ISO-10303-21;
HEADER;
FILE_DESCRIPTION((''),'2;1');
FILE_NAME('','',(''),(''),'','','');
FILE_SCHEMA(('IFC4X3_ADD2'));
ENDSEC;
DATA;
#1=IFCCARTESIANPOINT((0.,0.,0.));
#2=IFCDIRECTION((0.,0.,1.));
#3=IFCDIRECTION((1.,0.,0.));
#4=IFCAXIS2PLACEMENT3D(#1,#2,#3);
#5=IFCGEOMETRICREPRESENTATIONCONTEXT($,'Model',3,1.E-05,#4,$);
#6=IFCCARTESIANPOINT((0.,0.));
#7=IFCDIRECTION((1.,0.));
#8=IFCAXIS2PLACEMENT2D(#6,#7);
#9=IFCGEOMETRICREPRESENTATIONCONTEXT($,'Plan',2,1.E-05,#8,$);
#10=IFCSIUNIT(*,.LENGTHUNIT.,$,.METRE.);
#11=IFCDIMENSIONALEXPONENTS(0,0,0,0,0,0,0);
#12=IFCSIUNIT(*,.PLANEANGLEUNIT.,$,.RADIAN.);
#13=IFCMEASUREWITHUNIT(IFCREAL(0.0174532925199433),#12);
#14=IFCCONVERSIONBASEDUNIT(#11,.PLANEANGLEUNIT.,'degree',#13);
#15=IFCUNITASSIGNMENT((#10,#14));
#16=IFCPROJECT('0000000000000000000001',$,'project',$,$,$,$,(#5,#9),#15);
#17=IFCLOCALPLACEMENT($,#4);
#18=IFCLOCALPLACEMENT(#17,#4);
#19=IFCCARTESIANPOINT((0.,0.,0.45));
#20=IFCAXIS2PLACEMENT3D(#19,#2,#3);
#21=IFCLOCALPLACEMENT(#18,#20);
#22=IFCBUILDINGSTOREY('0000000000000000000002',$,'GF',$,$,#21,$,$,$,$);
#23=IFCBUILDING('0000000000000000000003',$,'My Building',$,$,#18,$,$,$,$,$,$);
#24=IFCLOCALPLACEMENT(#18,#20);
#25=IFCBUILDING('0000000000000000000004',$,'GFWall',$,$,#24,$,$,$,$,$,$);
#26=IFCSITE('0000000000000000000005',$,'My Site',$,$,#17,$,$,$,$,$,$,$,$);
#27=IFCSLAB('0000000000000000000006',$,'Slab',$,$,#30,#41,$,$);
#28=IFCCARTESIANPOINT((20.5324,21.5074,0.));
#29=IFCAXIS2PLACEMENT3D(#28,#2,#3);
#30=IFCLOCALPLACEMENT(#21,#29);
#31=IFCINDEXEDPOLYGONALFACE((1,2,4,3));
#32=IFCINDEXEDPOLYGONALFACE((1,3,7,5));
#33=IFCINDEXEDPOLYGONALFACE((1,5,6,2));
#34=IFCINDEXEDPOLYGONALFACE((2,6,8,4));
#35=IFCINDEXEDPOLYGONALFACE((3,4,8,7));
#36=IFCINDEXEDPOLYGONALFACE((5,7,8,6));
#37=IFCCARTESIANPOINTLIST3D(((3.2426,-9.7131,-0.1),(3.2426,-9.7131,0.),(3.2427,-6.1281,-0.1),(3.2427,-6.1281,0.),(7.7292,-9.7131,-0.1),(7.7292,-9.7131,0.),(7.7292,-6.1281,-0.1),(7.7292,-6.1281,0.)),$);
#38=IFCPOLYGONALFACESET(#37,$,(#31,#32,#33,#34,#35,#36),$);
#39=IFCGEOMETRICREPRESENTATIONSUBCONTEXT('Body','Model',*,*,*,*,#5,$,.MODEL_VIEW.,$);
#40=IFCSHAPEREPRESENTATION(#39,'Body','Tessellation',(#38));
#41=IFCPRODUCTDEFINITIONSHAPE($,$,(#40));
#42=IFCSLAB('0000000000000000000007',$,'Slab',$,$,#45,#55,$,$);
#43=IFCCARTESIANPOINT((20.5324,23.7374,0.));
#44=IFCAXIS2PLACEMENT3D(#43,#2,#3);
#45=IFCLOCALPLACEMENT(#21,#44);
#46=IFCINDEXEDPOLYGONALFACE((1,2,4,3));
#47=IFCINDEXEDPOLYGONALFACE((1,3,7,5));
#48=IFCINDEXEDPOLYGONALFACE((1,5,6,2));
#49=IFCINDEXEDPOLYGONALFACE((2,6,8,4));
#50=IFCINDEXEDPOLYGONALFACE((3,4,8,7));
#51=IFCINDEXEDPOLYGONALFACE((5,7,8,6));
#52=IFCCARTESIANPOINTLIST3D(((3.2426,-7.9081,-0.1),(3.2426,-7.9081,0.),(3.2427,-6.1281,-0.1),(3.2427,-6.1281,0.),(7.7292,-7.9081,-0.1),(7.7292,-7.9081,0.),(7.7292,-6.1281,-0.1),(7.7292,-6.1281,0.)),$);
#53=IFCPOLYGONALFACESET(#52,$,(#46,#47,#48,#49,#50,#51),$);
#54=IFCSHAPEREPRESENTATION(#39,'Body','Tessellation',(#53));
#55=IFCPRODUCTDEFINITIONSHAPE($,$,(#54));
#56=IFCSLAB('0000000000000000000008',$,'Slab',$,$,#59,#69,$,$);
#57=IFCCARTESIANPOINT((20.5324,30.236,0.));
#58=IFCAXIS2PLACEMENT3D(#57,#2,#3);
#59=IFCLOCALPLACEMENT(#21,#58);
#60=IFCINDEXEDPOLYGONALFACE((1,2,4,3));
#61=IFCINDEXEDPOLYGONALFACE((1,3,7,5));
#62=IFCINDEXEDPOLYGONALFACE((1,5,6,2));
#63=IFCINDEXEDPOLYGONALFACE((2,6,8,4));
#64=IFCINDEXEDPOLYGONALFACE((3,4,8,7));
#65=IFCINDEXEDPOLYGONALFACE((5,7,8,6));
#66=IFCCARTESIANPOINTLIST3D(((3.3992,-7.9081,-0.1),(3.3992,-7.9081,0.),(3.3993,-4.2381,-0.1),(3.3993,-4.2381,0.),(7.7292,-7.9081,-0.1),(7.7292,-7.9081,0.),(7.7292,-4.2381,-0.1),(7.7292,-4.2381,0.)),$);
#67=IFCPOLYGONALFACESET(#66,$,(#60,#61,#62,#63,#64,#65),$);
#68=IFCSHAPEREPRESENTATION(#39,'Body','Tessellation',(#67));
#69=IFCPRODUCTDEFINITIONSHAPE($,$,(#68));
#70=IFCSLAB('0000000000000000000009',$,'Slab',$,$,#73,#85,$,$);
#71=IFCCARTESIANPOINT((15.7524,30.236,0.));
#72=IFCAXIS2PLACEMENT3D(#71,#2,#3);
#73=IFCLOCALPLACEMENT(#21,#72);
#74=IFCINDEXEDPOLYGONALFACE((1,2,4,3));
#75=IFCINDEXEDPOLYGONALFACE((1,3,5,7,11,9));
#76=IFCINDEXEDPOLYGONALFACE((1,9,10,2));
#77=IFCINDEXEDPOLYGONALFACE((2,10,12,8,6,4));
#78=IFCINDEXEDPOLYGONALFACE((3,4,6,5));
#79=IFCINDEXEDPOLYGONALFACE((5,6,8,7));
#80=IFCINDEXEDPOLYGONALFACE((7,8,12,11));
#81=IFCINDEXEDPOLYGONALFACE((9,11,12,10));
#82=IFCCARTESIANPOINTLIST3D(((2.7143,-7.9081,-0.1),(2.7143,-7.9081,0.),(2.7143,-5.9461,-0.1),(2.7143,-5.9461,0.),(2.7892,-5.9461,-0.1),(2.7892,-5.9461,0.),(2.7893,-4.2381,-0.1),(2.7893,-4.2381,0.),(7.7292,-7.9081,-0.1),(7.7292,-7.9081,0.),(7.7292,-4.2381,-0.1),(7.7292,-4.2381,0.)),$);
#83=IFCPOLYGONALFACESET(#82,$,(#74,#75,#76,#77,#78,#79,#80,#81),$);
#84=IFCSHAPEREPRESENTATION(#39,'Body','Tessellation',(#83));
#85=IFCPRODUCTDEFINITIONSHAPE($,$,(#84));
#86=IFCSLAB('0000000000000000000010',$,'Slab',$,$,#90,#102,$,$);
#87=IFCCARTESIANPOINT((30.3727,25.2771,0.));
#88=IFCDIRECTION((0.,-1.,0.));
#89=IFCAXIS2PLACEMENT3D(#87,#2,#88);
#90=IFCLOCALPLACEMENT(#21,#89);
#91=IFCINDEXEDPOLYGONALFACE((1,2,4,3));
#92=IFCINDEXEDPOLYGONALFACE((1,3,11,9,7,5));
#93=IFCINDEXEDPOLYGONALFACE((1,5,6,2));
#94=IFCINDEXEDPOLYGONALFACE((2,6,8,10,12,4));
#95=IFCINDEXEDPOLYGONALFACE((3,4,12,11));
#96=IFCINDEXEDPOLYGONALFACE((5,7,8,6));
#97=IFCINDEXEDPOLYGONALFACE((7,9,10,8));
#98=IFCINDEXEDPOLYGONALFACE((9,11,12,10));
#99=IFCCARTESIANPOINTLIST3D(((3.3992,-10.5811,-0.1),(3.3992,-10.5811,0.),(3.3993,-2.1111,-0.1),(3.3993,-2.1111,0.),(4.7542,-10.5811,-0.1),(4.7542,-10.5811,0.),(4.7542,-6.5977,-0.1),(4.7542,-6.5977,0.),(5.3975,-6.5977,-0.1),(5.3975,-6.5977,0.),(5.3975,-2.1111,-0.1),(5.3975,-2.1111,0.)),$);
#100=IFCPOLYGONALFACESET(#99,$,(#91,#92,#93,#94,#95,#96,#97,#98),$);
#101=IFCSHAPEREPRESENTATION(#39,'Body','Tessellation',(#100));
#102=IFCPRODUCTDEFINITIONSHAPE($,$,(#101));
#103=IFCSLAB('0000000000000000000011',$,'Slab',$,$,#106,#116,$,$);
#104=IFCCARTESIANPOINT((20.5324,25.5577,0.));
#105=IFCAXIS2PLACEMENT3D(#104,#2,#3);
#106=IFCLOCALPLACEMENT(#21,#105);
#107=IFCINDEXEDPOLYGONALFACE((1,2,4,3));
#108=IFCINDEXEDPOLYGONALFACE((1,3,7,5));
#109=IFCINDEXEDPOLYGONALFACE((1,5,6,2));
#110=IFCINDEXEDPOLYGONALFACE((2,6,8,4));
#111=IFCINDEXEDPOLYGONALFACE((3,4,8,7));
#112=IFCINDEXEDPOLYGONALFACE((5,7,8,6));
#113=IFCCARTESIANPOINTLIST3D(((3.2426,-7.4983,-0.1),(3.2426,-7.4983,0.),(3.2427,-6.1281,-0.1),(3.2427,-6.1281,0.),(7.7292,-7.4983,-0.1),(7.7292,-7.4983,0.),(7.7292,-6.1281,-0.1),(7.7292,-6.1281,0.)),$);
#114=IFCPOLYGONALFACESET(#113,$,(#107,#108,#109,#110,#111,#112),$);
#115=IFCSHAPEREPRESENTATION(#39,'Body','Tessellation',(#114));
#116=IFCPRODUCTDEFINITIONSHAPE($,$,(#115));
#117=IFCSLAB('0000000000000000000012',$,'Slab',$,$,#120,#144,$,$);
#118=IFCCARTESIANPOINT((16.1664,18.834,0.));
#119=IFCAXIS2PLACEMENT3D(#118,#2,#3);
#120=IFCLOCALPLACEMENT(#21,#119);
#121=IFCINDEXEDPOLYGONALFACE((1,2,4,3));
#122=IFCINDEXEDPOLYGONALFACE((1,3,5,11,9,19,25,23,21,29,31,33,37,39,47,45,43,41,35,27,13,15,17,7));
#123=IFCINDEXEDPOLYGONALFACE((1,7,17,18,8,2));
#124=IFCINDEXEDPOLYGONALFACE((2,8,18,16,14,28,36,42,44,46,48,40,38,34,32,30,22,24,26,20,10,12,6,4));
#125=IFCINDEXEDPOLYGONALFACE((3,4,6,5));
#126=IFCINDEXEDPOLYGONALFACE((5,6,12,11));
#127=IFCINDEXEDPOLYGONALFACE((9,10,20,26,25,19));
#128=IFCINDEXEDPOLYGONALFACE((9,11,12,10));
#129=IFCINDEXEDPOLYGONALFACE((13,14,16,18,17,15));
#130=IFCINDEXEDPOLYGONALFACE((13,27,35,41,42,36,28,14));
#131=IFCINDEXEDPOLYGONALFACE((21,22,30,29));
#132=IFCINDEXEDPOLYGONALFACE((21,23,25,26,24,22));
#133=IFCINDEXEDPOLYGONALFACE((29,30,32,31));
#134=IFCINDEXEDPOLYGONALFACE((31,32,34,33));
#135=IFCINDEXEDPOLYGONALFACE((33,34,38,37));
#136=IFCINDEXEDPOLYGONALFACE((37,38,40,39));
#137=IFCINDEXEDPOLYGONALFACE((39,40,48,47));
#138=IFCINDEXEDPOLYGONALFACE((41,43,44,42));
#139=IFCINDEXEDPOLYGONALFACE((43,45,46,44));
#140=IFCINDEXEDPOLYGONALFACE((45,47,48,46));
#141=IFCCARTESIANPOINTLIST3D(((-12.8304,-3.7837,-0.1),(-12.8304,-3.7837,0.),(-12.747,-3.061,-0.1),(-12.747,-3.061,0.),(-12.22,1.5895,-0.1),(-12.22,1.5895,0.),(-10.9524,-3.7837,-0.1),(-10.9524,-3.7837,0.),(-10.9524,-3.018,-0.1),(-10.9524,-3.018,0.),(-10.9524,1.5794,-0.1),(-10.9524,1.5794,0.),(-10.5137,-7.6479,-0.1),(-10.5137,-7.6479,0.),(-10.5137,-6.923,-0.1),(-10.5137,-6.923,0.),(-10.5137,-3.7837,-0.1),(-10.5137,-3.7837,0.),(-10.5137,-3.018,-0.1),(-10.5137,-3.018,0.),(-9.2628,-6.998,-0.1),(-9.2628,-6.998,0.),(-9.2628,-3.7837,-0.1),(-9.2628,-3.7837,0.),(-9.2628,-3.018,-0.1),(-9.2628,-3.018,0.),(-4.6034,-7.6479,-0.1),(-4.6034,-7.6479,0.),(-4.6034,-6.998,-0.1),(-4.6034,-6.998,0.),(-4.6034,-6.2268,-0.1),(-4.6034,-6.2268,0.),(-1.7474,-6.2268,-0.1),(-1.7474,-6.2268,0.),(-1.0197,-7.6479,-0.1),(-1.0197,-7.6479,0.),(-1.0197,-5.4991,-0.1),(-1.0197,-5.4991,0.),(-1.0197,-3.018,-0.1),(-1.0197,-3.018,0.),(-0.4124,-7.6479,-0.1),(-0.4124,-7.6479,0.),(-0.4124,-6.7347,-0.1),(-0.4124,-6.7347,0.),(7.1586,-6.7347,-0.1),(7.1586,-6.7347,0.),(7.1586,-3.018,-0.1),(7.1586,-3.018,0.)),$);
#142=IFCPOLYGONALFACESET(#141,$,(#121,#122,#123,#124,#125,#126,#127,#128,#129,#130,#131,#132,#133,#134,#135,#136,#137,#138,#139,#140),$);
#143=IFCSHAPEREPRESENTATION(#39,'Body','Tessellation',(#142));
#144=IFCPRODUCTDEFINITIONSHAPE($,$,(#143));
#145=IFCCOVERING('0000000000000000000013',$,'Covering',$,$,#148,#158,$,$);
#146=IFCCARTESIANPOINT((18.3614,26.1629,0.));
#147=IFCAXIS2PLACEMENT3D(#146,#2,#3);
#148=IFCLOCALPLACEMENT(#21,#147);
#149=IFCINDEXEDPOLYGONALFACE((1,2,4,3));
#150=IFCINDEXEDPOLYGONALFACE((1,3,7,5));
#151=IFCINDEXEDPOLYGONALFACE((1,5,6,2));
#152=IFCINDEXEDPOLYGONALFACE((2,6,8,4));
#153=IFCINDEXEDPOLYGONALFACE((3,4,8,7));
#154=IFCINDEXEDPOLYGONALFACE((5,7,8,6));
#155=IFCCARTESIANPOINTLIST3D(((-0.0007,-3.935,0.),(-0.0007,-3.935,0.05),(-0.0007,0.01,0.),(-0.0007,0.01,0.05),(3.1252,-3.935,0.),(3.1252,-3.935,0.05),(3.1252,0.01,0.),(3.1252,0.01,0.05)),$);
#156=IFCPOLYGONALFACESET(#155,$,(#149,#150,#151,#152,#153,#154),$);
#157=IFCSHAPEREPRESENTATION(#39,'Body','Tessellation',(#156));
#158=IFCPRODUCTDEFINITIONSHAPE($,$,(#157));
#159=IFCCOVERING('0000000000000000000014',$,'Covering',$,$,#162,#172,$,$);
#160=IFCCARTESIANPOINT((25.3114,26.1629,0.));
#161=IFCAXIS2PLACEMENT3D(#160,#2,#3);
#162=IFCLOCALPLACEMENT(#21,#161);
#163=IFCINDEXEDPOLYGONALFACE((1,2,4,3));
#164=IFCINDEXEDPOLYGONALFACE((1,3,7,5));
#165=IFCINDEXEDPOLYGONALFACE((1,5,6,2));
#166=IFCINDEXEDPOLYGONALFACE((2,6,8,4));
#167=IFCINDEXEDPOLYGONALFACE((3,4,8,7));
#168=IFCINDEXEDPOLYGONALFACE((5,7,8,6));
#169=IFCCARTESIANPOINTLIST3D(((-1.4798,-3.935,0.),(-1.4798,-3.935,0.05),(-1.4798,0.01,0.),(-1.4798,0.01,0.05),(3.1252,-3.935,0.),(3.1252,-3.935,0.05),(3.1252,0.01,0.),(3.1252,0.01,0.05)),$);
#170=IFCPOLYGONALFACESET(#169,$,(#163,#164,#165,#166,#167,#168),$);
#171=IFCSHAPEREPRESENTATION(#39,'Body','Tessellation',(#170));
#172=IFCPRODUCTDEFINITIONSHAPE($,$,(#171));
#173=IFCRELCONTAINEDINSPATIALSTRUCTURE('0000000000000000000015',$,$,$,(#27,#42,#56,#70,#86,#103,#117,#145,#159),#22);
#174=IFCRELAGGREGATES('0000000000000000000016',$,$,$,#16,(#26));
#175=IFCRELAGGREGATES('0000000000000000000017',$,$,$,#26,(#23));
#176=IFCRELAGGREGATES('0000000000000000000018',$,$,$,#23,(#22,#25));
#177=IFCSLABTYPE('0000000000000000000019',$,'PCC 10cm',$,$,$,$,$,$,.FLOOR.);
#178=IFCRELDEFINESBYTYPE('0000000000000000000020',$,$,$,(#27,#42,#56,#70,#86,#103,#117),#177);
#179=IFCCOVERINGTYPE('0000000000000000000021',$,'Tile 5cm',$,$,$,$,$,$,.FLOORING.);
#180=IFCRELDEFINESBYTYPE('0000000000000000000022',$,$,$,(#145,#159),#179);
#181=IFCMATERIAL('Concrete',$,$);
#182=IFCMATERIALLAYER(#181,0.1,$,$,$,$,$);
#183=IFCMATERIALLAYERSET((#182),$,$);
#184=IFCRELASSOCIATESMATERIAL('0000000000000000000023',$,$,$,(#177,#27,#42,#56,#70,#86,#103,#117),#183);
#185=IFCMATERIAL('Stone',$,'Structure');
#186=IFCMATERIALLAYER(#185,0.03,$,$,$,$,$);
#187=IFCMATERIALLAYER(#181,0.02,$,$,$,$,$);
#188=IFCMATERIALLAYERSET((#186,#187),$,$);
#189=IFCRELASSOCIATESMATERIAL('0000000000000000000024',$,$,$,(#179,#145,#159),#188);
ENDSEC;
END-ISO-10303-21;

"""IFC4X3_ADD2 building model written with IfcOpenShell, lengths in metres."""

from ifc_helpers import new_model, entity, si_unit, converted_unit, frame, origin_with_axes, origin_2d_with_axis, place, context, subcontext, project, spatial, indexed_curve, outline, extrude, material, layer, layer_set, layer_usage, type_object, element, save


model = new_model("IFC4X3_ADD2")

# Units and contexts
model_context = context("Model", 3, precision=1e-05, world=origin_with_axes())
plan_context = context("Plan", 2, precision=1e-05, world=origin_2d_with_axis())
body_context_1 = subcontext(model_context, "Body", "Model", "MODEL_VIEW")
ifc_project = project(units=[si_unit("LENGTHUNIT", "METRE"), converted_unit("PLANEANGLEUNIT", "degree", entity("IfcReal", 0.0174532925199433), si_unit("PLANEANGLEUNIT", "RADIAN"), dimensions=[0, 0, 0, 0, 0, 0, 0])], contexts=[model_context, plan_context])

# Site, building, storey
site_placement = place(None, origin_with_axes())
site = spatial("IfcSite", under=ifc_project, at=site_placement, Name="My Site")
building_1_placement = place(site_placement, origin_with_axes())
building_1 = spatial("IfcBuilding", under=site, at=building_1_placement, Name="My Building")
storey_placement = place(building_1_placement, frame((0.0, 0.0, 0.45), z_axis=(0.0, 0.0, 1.0), x_axis=(1.0, 0.0, 0.0)))
storey = spatial("IfcBuildingStorey", under=building_1, at=storey_placement, Name="GF")

# Slabs
ifc_material_1 = material(Name="Concrete")
ifc_layer_1 = layer(ifc_material_1, 0.1)
ifc_layer_set_1 = layer_set([ifc_layer_1])
ifc_layer_usage_1 = layer_usage(ifc_layer_set_1, "AXIS3", "POSITIVE", -0.1)
slab_type = type_object("IfcSlabType", Name="PCC 10cm", PredefinedType="FLOOR", material=ifc_layer_set_1)
slab_1_placement = place(storey_placement, frame((20.5324, 21.5074, 0.0), z_axis=(0.0, 0.0, 1.0), x_axis=(1.0, 0.0, 0.0)))
element("IfcSlab", 1, at=slab_1_placement, inside=storey, type_object=slab_type, material=ifc_layer_usage_1, Name="Slab", context=body_context_1, shape_type="SweptSolid", body=[
    extrude(outline(indexed_curve([(3.2426, -9.7131), (7.7292, -9.7131), (7.7292, -6.1281), (3.2427, -6.1281), (3.2426, -9.7131)])), frame((0.0, 0.0, -0.1), z_axis=(0.0, 0.0, 1.0), x_axis=(1.0, 0.0, 0.0)), (0.0, 0.0, 1.0), 0.1),
])
ifc_layer_usage_2 = layer_usage(ifc_layer_set_1, "AXIS3", "POSITIVE", -0.1)
slab_2_placement = place(storey_placement, frame((20.5324, 23.7374, 0.0), z_axis=(0.0, 0.0, 1.0), x_axis=(1.0, 0.0, 0.0)))
element("IfcSlab", 2, at=slab_2_placement, inside=storey, type_object=slab_type, material=ifc_layer_usage_2, Name="Slab", context=body_context_1, shape_type="SweptSolid", body=[
    extrude(outline(indexed_curve([(3.2427, -6.1281), (7.7292, -6.1281), (7.7292, -7.9081), (3.2426, -7.9081), (3.2427, -6.1281)])), frame((0.0, 0.0, -0.1), z_axis=(0.0, 0.0, 1.0), x_axis=(1.0, 0.0, 0.0)), (0.0, 0.0, 1.0), 0.1),
])
ifc_layer_usage_3 = layer_usage(ifc_layer_set_1, "AXIS3", "POSITIVE", -0.1)
slab_3_placement = place(storey_placement, frame((20.5324, 30.236, 0.0), z_axis=(0.0, 0.0, 1.0), x_axis=(1.0, 0.0, 0.0)))
element("IfcSlab", 3, at=slab_3_placement, inside=storey, type_object=slab_type, material=ifc_layer_usage_3, Name="Slab", context=body_context_1, shape_type="SweptSolid", body=[
    extrude(outline(indexed_curve([(3.3992, -7.9081), (7.7292, -7.9081), (7.7292, -4.2381), (3.3993, -4.2381), (3.3992, -7.9081)])), frame((0.0, 0.0, -0.1), z_axis=(0.0, 0.0, 1.0), x_axis=(1.0, 0.0, 0.0)), (0.0, 0.0, 1.0), 0.1),
])
ifc_layer_usage_4 = layer_usage(ifc_layer_set_1, "AXIS3", "POSITIVE", -0.1)
slab_4_placement = place(storey_placement, frame((15.7524, 30.236, 0.0), z_axis=(0.0, 0.0, 1.0), x_axis=(1.0, 0.0, 0.0)))
element("IfcSlab", 4, at=slab_4_placement, inside=storey, type_object=slab_type, material=ifc_layer_usage_4, Name="Slab", context=body_context_1, shape_type="SweptSolid", body=[
    extrude(outline(indexed_curve([(2.7893, -4.2381), (7.7292, -4.2381), (7.7292, -7.9081), (2.7143, -7.9081), (2.7143, -5.9461), (2.7892, -5.9461), (2.7893, -4.2381)])), frame((0.0, 0.0, -0.1), z_axis=(0.0, 0.0, 1.0), x_axis=(1.0, 0.0, 0.0)), (0.0, 0.0, 1.0), 0.1),
])
ifc_layer_usage_5 = layer_usage(ifc_layer_set_1, "AXIS3", "POSITIVE", -0.1)
slab_5_placement = place(storey_placement, frame((30.3727, 25.2771, 0.0), z_axis=(0.0, 0.0, 1.0), x_axis=(0.0, -1.0, 0.0)))
element("IfcSlab", 5, at=slab_5_placement, inside=storey, type_object=slab_type, material=ifc_layer_usage_5, Name="Slab", context=body_context_1, shape_type="SweptSolid", body=[
    extrude(outline(indexed_curve([(5.3975, -6.5977), (4.7542, -6.5977), (4.7542, -10.5811), (3.3992, -10.5811), (3.3993, -2.1111), (5.3975, -2.1111), (5.3975, -6.5977)])), frame((0.0, 0.0, -0.1), z_axis=(0.0, 0.0, 1.0), x_axis=(1.0, 0.0, 0.0)), (0.0, 0.0, 1.0), 0.1),
])
ifc_layer_usage_6 = layer_usage(ifc_layer_set_1, "AXIS3", "POSITIVE", -0.1)
slab_6_placement = place(storey_placement, frame((20.5324, 25.5577, 0.0), z_axis=(0.0, 0.0, 1.0), x_axis=(1.0, 0.0, 0.0)))
element("IfcSlab", 6, at=slab_6_placement, inside=storey, type_object=slab_type, material=ifc_layer_usage_6, Name="Slab", context=body_context_1, shape_type="SweptSolid", body=[
    extrude(outline(indexed_curve([(3.2426, -7.4983), (7.7292, -7.4983), (7.7292, -6.1281), (3.2427, -6.1281), (3.2426, -7.4983)])), frame((0.0, 0.0, -0.1), z_axis=(0.0, 0.0, 1.0), x_axis=(1.0, 0.0, 0.0)), (0.0, 0.0, 1.0), 0.1),
])
ifc_layer_usage_7 = layer_usage(ifc_layer_set_1, "AXIS3", "POSITIVE", -0.1)
slab_7_placement = place(storey_placement, frame((16.1664, 18.834, 0.0), z_axis=(0.0, 0.0, 1.0), x_axis=(1.0, 0.0, 0.0)))
element("IfcSlab", 7, at=slab_7_placement, inside=storey, type_object=slab_type, material=ifc_layer_usage_7, Name="Slab", context=body_context_1, shape_type="SweptSolid", body=[
    extrude(outline(indexed_curve([(-1.0197, -5.4991), (-1.0197, -3.018), (7.1586, -3.018), (7.1586, -6.7347), (-0.4124, -6.7347), (-0.4124, -7.6479), (-1.0197, -7.6479), (-4.6034, -7.6479), (-10.5137, -7.6479), (-10.5137, -6.923), (-10.5137, -3.7837), (-10.9524, -3.7837), (-12.8304, -3.7837), (-12.747, -3.061), (-12.22, 1.5895), (-10.9524, 1.5794), (-10.9524, -3.018), (-10.5137, -3.018), (-9.2628, -3.018), (-9.2628, -3.7837), (-9.2628, -6.998), (-4.6034, -6.998), (-4.6034, -6.2268), (-1.7474, -6.2268), (-1.0197, -5.4991)])), frame((0.0, 0.0, -0.1), z_axis=(0.0, 0.0, 1.0), x_axis=(1.0, 0.0, 0.0)), (0.0, 0.0, 1.0), 0.1),
])

# Shared definitions
building_2_placement = place(building_1_placement, frame((0.0, 0.0, 0.45), z_axis=(0.0, 0.0, 1.0), x_axis=(1.0, 0.0, 0.0)))
building_2 = spatial("IfcBuilding", under=building_1, at=building_2_placement, Name="GFWall")

# Coverings
ifc_material_2 = material(Name="Stone", Category="Structure")
ifc_layer_2 = layer(ifc_material_2, 0.03)
ifc_layer_3 = layer(ifc_material_1, 0.02)
ifc_layer_set_2 = layer_set([ifc_layer_2, ifc_layer_3])
ifc_layer_usage_8 = layer_usage(ifc_layer_set_2, "AXIS3", "POSITIVE", 0.0)
covering_type = type_object("IfcCoveringType", Name="Tile 5cm", PredefinedType="FLOORING", material=ifc_layer_set_2)
covering_1_placement = place(storey_placement, frame((18.3614, 26.1629, 0.0), z_axis=(0.0, 0.0, 1.0), x_axis=(1.0, 0.0, 0.0)))
element("IfcCovering", 8, at=covering_1_placement, inside=storey, type_object=covering_type, material=ifc_layer_usage_8, Name="Covering", context=body_context_1, shape_type="SweptSolid", body=[
    extrude(outline(indexed_curve([(-0.0007, -3.935), (3.1252, -3.935), (3.1252, 0.01), (-0.0007, 0.01), (-0.0007, -3.935)])), None, (0.0, 0.0, 1.0), 0.05),
])
ifc_layer_usage_9 = layer_usage(ifc_layer_set_2, "AXIS3", "POSITIVE", 0.0)
covering_2_placement = place(storey_placement, frame((25.3114, 26.1629, 0.0), z_axis=(0.0, 0.0, 1.0), x_axis=(1.0, 0.0, 0.0)))
element("IfcCovering", 9, at=covering_2_placement, inside=storey, type_object=covering_type, material=ifc_layer_usage_9, Name="Covering", context=body_context_1, shape_type="SweptSolid", body=[
    extrude(outline(indexed_curve([(-1.4798, 0.01), (3.1252, 0.01), (3.1252, -3.935), (-1.4798, -3.935), (-1.4798, 0.01)])), None, (0.0, 0.0, 1.0), 0.05),
])

save(model, "model.ifc")
